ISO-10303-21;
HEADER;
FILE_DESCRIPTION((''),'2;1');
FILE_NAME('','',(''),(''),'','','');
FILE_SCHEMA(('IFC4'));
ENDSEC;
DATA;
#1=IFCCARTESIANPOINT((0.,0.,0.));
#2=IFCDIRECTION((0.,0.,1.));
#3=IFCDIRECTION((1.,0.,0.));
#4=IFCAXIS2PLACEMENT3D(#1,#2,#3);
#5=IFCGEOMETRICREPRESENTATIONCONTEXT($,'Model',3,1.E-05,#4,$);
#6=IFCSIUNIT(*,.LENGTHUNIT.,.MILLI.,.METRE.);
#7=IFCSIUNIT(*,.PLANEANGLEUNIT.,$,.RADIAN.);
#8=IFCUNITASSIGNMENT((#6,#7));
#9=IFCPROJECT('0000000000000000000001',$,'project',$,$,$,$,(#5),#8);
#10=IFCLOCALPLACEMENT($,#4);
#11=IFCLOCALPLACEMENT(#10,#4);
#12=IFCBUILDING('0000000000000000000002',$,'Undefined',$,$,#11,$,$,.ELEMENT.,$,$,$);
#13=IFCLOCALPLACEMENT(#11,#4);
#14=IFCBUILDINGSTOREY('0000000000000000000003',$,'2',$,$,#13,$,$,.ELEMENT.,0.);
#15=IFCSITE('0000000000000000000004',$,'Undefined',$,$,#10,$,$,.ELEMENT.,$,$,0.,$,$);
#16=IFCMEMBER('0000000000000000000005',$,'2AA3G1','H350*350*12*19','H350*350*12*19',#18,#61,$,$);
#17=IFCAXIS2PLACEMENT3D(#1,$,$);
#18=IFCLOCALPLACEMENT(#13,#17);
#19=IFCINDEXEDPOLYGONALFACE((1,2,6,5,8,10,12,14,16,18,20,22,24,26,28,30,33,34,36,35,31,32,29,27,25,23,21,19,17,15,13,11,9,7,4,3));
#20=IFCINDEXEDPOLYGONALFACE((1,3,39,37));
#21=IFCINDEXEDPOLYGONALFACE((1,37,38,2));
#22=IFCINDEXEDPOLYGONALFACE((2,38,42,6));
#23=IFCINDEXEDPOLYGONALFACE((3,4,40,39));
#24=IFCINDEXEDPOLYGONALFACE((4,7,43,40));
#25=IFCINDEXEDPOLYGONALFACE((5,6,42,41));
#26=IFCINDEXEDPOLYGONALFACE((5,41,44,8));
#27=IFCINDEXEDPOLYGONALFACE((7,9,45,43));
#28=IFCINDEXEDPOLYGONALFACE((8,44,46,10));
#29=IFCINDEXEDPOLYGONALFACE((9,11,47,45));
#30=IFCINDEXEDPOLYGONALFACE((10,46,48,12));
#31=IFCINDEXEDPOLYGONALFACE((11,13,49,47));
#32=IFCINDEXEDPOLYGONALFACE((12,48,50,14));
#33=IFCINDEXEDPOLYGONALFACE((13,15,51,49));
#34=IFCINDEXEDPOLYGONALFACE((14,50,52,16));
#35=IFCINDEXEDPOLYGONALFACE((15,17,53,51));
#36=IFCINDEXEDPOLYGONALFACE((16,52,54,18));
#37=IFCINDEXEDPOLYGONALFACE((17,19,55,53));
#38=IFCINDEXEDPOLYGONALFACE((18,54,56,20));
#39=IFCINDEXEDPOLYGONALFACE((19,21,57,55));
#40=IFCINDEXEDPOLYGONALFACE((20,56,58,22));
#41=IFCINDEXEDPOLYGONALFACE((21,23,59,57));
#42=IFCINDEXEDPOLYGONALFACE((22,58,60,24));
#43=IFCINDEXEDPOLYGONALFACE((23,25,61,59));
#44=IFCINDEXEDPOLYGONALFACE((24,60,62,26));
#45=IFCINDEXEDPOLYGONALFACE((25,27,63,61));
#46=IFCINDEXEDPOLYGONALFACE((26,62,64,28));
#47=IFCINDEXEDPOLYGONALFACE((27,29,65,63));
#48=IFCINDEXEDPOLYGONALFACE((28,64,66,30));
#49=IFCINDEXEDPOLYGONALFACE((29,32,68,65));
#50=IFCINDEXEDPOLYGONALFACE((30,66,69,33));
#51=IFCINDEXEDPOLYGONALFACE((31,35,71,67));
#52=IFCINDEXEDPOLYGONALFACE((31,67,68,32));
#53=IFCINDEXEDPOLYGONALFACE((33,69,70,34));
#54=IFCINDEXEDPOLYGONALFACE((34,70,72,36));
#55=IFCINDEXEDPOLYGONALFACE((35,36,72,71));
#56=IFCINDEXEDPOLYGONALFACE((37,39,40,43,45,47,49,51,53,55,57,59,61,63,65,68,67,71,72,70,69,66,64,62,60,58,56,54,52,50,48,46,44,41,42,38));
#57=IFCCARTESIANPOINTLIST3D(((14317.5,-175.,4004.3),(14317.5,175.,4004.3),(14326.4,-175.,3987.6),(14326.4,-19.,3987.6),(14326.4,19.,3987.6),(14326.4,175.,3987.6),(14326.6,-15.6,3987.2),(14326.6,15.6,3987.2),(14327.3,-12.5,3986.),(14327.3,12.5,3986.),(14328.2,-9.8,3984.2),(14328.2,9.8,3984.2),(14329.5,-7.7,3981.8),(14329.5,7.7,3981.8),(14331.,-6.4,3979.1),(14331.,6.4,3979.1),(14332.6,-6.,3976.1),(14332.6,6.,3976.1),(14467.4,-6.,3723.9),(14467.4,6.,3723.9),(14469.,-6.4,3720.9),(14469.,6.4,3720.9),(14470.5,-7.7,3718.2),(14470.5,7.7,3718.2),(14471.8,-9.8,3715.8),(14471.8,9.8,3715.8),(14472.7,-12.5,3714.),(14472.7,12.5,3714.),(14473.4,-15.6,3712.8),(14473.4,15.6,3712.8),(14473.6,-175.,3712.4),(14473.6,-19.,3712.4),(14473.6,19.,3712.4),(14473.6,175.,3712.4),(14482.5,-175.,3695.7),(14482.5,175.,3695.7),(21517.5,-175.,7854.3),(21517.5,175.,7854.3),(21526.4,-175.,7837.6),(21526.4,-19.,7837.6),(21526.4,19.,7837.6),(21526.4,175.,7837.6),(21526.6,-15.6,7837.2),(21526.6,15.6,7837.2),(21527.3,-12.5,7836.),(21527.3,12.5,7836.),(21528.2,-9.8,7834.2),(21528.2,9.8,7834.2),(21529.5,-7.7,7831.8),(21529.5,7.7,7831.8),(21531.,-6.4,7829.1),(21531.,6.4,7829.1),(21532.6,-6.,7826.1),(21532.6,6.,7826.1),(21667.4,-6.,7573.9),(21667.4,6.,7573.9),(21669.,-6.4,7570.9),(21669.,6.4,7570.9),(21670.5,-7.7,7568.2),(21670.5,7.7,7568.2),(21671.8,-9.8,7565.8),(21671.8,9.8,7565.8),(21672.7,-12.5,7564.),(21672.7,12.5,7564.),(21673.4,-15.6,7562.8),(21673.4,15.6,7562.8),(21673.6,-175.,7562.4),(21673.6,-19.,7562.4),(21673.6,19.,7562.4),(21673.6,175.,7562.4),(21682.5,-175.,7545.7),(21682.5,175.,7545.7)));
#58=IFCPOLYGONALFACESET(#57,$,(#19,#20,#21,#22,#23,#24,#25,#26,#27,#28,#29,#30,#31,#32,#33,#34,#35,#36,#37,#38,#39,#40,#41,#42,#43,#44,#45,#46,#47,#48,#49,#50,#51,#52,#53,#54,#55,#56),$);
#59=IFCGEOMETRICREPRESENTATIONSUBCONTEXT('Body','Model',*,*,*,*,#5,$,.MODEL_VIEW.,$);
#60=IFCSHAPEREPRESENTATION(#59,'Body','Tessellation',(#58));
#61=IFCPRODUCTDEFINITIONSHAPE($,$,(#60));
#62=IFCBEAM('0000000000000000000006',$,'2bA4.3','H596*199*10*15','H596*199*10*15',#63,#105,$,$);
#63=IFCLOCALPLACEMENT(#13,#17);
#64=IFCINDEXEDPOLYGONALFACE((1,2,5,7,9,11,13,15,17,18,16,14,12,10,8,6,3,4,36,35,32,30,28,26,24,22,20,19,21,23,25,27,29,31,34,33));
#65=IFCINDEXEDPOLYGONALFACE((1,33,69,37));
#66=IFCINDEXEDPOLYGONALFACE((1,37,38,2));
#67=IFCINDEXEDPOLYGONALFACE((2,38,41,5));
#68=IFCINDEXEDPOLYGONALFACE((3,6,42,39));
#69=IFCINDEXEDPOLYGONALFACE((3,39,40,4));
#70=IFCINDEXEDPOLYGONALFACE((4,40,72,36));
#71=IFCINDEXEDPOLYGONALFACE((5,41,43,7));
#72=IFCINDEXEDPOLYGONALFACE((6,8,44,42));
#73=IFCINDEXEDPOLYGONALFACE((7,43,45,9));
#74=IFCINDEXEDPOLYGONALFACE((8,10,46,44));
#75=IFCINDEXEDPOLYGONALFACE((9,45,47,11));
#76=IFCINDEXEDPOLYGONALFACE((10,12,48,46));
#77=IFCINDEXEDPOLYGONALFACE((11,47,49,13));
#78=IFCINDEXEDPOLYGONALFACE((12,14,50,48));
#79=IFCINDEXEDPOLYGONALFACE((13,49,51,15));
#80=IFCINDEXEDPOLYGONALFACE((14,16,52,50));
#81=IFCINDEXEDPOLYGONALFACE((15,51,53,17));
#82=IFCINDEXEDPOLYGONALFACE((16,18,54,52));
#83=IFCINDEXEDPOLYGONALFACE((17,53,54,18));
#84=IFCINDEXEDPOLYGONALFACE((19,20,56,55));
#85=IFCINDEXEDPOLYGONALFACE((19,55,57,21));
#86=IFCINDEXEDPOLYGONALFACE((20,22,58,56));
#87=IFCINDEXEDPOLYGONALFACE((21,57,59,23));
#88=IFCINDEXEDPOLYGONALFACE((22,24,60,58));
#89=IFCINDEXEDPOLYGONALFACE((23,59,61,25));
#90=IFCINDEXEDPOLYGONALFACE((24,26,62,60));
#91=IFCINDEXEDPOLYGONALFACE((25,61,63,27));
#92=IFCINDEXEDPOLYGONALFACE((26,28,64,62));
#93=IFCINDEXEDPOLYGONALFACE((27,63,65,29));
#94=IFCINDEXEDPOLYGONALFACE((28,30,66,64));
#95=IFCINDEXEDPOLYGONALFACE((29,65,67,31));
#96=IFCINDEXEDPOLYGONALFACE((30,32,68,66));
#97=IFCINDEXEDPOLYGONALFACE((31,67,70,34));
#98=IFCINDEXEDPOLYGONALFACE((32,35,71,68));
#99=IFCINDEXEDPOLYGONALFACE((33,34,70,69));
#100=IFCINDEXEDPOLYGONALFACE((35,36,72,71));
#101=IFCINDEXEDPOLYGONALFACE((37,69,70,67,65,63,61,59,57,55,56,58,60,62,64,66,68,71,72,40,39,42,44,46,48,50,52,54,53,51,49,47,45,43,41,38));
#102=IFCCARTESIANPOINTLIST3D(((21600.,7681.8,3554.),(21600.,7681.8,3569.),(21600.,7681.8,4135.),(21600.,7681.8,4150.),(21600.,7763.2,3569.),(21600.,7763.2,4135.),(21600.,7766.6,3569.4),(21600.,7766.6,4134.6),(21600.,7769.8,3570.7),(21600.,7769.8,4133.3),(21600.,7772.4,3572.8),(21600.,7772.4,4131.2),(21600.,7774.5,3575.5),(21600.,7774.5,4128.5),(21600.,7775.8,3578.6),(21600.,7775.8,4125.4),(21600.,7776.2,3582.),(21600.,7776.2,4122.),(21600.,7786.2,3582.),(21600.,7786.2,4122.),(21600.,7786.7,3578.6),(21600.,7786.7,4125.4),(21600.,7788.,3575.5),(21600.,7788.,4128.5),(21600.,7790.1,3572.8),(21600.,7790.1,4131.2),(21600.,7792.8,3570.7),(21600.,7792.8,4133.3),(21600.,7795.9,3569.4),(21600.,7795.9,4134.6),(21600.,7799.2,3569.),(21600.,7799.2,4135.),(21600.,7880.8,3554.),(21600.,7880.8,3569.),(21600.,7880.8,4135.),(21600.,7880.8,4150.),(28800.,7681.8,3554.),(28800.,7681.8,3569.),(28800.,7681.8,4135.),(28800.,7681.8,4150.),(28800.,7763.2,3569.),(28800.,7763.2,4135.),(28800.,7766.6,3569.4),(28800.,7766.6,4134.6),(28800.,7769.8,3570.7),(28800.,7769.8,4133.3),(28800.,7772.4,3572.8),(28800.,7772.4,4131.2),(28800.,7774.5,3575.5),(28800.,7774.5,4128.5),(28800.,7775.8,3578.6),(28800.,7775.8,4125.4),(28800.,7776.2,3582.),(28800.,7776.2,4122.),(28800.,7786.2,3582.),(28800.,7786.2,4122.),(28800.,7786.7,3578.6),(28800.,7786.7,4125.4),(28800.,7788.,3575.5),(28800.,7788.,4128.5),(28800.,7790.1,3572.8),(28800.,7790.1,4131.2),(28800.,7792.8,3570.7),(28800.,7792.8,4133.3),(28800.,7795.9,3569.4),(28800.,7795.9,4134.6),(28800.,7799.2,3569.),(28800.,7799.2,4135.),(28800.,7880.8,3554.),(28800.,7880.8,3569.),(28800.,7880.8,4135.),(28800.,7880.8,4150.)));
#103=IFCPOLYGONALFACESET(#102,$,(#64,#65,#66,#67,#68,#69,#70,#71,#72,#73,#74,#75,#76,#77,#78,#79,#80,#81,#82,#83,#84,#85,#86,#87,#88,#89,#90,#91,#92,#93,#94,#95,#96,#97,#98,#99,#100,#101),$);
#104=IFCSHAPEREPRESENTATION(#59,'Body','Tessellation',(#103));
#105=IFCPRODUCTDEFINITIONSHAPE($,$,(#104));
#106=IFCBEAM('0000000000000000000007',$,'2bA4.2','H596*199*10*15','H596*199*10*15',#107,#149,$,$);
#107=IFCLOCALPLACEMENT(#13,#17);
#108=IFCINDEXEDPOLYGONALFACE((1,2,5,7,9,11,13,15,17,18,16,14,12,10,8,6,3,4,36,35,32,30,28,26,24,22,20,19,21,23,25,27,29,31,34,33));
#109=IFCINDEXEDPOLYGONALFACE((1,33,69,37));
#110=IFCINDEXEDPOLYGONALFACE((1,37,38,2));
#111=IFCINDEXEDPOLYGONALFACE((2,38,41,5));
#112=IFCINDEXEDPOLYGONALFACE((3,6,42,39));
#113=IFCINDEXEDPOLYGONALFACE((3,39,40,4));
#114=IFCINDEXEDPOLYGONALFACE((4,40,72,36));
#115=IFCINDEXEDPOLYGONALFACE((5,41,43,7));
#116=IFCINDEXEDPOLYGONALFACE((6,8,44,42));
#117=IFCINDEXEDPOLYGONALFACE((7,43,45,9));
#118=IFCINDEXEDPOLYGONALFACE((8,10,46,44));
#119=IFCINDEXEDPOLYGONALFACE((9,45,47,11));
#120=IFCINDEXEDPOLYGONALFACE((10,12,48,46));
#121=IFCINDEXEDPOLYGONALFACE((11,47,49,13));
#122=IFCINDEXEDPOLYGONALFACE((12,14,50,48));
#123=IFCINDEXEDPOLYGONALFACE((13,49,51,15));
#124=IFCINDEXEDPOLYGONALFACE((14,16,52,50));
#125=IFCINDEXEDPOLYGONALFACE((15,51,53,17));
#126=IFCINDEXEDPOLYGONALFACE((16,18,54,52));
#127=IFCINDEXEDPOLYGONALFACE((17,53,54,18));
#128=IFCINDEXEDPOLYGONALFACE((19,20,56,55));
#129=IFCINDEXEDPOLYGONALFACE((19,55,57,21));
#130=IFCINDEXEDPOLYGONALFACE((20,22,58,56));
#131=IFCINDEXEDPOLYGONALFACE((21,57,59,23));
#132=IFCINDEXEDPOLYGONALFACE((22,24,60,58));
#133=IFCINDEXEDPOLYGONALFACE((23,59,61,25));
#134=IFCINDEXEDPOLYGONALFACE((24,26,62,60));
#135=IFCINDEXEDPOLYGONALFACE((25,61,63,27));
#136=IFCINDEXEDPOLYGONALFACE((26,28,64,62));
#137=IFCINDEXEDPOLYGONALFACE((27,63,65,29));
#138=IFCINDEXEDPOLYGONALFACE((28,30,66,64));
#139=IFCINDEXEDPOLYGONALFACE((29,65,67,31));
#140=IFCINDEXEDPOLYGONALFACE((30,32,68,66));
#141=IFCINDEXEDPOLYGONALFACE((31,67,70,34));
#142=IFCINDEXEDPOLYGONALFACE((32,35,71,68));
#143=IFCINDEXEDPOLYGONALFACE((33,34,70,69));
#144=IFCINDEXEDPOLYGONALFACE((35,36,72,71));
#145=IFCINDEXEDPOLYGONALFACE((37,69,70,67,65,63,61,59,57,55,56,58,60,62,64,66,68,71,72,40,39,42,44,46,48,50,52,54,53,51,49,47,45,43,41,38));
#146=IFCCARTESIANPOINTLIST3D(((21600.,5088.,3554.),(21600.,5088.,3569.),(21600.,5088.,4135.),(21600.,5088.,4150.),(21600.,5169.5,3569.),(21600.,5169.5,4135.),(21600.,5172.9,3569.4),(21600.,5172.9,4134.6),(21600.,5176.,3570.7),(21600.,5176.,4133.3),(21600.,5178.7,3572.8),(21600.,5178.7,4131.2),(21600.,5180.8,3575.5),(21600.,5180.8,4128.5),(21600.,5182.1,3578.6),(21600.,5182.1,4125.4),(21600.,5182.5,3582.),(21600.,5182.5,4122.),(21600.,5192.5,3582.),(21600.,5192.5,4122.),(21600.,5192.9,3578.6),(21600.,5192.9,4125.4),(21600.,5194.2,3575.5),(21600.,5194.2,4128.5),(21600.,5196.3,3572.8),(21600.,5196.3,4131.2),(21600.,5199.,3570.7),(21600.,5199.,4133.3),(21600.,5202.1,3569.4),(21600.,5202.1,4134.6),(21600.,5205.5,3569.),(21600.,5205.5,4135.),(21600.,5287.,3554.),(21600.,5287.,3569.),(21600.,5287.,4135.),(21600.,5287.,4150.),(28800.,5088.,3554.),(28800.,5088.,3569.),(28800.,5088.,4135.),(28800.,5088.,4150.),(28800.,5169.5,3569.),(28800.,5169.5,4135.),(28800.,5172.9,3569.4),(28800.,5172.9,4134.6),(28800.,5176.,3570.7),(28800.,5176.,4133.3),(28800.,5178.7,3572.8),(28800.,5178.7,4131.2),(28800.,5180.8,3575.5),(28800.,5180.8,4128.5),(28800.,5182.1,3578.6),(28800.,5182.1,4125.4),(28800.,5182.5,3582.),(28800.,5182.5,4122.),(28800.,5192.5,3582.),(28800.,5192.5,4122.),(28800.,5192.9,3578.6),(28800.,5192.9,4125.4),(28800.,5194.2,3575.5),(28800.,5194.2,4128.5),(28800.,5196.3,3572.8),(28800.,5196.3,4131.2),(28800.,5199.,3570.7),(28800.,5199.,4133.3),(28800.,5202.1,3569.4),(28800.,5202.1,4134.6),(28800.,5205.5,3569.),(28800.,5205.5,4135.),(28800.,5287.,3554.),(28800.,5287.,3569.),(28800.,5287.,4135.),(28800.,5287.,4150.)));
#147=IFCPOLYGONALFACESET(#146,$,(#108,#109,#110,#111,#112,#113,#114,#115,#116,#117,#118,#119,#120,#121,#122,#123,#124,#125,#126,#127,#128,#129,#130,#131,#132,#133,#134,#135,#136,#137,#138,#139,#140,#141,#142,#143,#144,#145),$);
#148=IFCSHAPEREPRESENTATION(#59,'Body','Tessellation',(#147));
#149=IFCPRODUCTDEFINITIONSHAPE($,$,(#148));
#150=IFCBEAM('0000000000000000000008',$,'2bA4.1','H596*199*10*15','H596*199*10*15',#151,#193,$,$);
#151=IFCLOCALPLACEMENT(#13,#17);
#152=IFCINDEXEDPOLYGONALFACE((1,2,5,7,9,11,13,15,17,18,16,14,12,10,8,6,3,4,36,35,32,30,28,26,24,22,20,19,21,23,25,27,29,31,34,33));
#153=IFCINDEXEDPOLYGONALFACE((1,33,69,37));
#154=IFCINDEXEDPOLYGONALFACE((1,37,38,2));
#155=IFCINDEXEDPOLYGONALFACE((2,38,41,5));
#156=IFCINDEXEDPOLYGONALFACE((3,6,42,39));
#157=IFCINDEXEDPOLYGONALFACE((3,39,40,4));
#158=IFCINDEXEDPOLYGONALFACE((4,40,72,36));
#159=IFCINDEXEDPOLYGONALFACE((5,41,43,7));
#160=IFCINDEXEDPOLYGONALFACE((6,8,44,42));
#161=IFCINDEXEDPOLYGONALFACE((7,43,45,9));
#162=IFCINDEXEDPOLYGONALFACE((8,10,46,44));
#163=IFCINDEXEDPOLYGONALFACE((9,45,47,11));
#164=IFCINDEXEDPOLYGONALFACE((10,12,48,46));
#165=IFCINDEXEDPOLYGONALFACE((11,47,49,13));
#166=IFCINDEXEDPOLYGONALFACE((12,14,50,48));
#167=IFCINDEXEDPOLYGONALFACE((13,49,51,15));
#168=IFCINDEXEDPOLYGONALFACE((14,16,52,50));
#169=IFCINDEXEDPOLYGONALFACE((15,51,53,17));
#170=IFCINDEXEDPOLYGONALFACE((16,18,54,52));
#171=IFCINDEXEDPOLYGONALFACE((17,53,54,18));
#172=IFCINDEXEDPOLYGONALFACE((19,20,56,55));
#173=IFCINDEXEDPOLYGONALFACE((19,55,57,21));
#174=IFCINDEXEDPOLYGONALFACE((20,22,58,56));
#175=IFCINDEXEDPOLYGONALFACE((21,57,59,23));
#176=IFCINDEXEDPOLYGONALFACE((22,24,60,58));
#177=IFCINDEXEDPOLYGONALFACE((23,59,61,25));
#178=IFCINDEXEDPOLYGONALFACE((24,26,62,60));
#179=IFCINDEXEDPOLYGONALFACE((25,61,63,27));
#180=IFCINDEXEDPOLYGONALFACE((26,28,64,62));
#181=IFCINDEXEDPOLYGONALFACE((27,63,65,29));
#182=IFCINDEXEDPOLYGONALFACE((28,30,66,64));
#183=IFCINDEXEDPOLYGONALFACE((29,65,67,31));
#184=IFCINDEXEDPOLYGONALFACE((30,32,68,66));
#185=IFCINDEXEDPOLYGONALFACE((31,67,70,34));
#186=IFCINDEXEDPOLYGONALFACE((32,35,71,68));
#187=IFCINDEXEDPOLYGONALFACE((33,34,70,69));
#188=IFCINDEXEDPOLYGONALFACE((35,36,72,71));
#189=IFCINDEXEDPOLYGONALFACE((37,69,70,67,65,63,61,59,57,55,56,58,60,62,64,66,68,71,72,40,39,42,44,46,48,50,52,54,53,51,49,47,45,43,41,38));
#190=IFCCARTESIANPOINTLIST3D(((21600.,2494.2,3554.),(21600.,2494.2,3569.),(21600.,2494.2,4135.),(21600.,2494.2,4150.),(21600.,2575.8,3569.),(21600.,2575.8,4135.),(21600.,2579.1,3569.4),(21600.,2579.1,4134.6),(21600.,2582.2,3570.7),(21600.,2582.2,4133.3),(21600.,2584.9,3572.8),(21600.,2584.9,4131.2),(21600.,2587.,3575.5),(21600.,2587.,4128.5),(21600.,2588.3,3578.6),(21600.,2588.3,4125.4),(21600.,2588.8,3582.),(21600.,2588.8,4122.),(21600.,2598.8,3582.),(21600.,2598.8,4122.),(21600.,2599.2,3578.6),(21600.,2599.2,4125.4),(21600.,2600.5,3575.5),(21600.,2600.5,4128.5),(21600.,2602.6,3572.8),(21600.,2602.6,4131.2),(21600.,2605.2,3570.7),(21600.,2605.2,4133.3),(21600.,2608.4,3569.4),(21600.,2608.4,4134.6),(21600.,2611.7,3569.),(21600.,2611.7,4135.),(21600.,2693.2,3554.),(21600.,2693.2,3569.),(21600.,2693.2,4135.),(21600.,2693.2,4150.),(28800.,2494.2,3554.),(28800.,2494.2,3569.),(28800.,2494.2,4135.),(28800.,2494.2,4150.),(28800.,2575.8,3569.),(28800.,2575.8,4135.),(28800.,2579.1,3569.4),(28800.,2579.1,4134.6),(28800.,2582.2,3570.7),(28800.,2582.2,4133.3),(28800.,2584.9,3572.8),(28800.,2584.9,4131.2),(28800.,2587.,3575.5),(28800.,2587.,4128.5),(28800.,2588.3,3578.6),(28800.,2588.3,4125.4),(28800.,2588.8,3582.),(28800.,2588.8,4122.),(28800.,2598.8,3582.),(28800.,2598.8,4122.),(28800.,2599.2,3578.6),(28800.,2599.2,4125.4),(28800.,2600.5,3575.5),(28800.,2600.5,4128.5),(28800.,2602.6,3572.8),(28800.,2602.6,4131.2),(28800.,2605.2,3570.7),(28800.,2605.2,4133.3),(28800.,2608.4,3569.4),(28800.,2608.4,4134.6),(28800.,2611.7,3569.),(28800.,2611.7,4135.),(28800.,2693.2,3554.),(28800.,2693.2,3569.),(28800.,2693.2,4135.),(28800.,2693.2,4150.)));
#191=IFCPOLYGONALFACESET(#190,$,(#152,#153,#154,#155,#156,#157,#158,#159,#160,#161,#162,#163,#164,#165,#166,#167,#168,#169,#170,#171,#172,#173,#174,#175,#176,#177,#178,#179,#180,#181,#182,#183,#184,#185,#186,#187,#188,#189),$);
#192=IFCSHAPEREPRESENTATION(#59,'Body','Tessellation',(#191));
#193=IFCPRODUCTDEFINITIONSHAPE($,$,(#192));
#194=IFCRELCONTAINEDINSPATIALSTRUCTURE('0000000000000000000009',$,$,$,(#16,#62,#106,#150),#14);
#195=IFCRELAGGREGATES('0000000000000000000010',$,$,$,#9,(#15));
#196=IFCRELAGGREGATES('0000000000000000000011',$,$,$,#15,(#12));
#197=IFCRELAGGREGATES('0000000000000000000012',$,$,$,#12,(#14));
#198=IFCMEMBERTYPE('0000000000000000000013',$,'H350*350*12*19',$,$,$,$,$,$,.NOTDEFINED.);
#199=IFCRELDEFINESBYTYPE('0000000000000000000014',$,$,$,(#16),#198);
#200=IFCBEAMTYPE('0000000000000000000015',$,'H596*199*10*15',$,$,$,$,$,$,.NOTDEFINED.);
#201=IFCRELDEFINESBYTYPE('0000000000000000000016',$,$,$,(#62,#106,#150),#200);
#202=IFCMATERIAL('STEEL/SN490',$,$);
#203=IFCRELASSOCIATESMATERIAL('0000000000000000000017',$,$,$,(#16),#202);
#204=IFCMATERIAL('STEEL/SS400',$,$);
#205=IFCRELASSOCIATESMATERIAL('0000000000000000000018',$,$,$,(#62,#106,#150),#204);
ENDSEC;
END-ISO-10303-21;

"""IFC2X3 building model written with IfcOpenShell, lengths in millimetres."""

from ifc_helpers import new_model, si_unit, frame, origin_with_axes, origin_2d_with_axis, place, context, subcontext, project, spatial, i_section, extrude, material, type_object, element, save


model = new_model("IFC2X3")

# Units and contexts
model_context = context("Model", 3, precision=1e-05, world=origin_with_axes())
body_context = subcontext(model_context, "Body", "Model", "MODEL_VIEW")
ifc_project = project(units=[si_unit("LENGTHUNIT", "METRE", prefix="MILLI"), si_unit("PLANEANGLEUNIT", "RADIAN")], contexts=[model_context])

# Site, building, storey
site_placement = place(None, origin_with_axes())
site = spatial("IfcSite", under=ifc_project, at=site_placement, Name="Undefined", CompositionType="ELEMENT", RefElevation=0.0)
building_placement = place(site_placement, origin_with_axes())
building = spatial("IfcBuilding", under=site, at=building_placement, Name="Undefined", CompositionType="ELEMENT")
storey_placement = place(building_placement, origin_with_axes())
storey = spatial("IfcBuildingStorey", under=building, at=storey_placement, Name="2", CompositionType="ELEMENT", Elevation=0.0)

# Shared definitions
ifc_material_1 = material(Name="STEEL/SN490")

# Member
member_type = type_object("IfcMemberType", Name="H350*350*12*19", PredefinedType="NOTDEFINED")
member_placement = place(storey_placement, frame((14400.0, 0.0, 3850.0), z_axis=(-0.471542, 0.0, 0.881844), x_axis=(0.881844, 0.0, 0.471542)))
element("IfcMember", 1, at=member_placement, inside=storey, type_object=member_type, material=ifc_material_1, Name="2AA3G1", Description="H350*350*12*19", ObjectType="H350*350*12*19", context=body_context, shape_type="SweptSolid", body=[
    extrude(i_section(OverallWidth=350.0, OverallDepth=350.0, WebThickness=12.0, FlangeThickness=19.0, FilletRadius=13.0, at=origin_2d_with_axis()), frame((8164.7, 0.0, 0.0), z_axis=(-1.0, 0.0, 0.0), x_axis=(0.0, -1.0, 0.0)), (0.0, 0.0, 1.0), 8164.7),
])

# Beams
ifc_material_2 = material(Name="STEEL/SS400")
beam_type_1 = type_object("IfcBeamType", Name="H596*199*10*15", PredefinedType="NOTDEFINED")
for number, where, z_axis, x_axis, name in (
    (2, (21600.0, 7781.2, 3852.0), (0.0, 0.0, 1.0), (1.0, 0.0, 0.0), "2bA4.3"),
    (3, (21600.0, 5187.5, 3852.0), (0.0, 0.0, 1.0), (1.0, 0.0, 0.0), "2bA4.2"),
    (4, (21600.0, 2593.8, 3852.0), (0.0, 0.0, 1.0), (1.0, 0.0, 0.0), "2bA4.1"),
):
    element("IfcBeam", number, at=place(storey_placement, frame(where, z_axis=z_axis, x_axis=x_axis)), inside=storey, type_object=beam_type_1, material=ifc_material_2, Name=name, Description="H596*199*10*15", ObjectType="H596*199*10*15", context=body_context, shape_type="SweptSolid", body=[
        extrude(i_section(OverallWidth=199.0, OverallDepth=596.0, WebThickness=10.0, FlangeThickness=15.0, FilletRadius=13.0, at=origin_2d_with_axis()), frame((7200.0, 0.0, 0.0), z_axis=(-1.0, 0.0, 0.0), x_axis=(0.0, -1.0, 0.0)), (0.0, 0.0, 1.0), 7200.0),
    ])

save(model, "model.ifc")
